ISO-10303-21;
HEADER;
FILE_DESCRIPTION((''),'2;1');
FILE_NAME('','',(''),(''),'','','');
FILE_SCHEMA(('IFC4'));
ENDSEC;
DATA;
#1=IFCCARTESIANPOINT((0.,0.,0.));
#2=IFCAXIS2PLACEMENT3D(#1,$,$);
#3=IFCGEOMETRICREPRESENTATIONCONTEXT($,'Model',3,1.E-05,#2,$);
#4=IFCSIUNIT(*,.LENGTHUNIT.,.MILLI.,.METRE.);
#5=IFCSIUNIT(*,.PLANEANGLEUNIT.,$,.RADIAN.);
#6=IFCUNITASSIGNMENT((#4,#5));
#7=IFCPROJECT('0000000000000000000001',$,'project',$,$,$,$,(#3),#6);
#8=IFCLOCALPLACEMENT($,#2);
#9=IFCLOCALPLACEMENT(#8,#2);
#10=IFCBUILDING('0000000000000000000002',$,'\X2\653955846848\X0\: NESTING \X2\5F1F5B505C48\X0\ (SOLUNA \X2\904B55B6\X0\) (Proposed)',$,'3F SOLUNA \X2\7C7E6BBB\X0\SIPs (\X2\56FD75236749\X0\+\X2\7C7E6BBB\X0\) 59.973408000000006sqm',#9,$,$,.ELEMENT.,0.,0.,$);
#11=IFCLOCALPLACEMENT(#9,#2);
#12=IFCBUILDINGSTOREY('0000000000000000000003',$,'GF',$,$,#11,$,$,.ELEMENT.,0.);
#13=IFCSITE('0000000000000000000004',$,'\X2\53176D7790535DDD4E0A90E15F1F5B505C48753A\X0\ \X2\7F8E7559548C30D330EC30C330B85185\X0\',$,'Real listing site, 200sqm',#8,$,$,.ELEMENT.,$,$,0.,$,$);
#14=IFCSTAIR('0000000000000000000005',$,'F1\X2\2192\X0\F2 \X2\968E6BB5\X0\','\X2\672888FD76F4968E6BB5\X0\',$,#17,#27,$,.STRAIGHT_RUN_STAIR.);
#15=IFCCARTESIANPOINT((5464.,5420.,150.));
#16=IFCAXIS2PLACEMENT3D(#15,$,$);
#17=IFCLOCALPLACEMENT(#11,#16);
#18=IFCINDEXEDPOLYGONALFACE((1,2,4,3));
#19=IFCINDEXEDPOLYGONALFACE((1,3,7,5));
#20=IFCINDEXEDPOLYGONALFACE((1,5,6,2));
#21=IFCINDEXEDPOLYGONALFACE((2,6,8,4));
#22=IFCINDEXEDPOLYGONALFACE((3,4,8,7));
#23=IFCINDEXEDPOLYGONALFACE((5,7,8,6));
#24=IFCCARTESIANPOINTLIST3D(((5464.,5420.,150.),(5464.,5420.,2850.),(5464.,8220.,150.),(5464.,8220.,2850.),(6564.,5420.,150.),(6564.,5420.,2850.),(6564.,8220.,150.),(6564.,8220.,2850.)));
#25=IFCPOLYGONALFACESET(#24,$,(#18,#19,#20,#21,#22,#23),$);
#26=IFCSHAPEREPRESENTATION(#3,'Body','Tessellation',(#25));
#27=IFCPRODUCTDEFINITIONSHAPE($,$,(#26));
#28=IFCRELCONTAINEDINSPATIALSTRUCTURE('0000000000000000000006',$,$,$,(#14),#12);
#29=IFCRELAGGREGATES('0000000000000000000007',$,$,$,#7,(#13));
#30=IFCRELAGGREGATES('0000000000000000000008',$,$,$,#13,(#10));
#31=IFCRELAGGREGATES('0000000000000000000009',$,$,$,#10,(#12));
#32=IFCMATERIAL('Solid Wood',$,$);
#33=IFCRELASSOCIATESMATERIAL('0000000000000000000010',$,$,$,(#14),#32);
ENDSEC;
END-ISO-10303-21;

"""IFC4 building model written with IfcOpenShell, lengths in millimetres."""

from ifc_helpers import new_model, si_unit, frame, frame_2d, origin, place, context, project, spatial, rectangle, extrude, material, element, save


model = new_model("IFC4")

# Units and contexts
model_context = context("Model", 3, precision=1e-05, world=origin())
ifc_project = project(units=[si_unit("LENGTHUNIT", "METRE", prefix="MILLI"), si_unit("PLANEANGLEUNIT", "RADIAN")], contexts=[model_context])

# Site, building, storey
site_placement = place(None, origin())
site = spatial("IfcSite", under=ifc_project, at=site_placement, Name="北海道川上郡弟子屈町 美留和ビレッジ内", ObjectType="Real listing site, 200sqm", CompositionType="ELEMENT", RefElevation=0.0)
building_placement = place(site_placement, origin())
building = spatial("IfcBuilding", under=site, at=building_placement, Name="改善案: NESTING 弟子屈 (SOLUNA 運営) (Proposed)", ObjectType="3F SOLUNA 籾殻SIPs (国産杉+籾殻) 59.973408000000006sqm", CompositionType="ELEMENT", ElevationOfRefHeight=0.0, ElevationOfTerrain=0.0)
storey_placement = place(building_placement, origin())
storey = spatial("IfcBuildingStorey", under=building, at=storey_placement, Name="GF", CompositionType="ELEMENT", Elevation=0.0)

# Shared definitions
ifc_material_1 = material(Name="Solid Wood")

# Stair
stair_placement = place(storey_placement, frame((5464.0, 5420.0, 150.0)))
element("IfcStair", 1, at=stair_placement, inside=storey, material=ifc_material_1, Name="F1→F2 階段", Description="木製直階段", PredefinedType="STRAIGHT_RUN_STAIR", context=model_context, shape_type="SweptSolid", body=[
    extrude(rectangle(XDim=1100.0, YDim=2800.0, at=frame_2d((550.0, 1400.0))), frame((5464.0, 5420.0, 150.0)), (0.0, 0.0, 1.0), 2700.0),
])

save(model, "model.ifc")
